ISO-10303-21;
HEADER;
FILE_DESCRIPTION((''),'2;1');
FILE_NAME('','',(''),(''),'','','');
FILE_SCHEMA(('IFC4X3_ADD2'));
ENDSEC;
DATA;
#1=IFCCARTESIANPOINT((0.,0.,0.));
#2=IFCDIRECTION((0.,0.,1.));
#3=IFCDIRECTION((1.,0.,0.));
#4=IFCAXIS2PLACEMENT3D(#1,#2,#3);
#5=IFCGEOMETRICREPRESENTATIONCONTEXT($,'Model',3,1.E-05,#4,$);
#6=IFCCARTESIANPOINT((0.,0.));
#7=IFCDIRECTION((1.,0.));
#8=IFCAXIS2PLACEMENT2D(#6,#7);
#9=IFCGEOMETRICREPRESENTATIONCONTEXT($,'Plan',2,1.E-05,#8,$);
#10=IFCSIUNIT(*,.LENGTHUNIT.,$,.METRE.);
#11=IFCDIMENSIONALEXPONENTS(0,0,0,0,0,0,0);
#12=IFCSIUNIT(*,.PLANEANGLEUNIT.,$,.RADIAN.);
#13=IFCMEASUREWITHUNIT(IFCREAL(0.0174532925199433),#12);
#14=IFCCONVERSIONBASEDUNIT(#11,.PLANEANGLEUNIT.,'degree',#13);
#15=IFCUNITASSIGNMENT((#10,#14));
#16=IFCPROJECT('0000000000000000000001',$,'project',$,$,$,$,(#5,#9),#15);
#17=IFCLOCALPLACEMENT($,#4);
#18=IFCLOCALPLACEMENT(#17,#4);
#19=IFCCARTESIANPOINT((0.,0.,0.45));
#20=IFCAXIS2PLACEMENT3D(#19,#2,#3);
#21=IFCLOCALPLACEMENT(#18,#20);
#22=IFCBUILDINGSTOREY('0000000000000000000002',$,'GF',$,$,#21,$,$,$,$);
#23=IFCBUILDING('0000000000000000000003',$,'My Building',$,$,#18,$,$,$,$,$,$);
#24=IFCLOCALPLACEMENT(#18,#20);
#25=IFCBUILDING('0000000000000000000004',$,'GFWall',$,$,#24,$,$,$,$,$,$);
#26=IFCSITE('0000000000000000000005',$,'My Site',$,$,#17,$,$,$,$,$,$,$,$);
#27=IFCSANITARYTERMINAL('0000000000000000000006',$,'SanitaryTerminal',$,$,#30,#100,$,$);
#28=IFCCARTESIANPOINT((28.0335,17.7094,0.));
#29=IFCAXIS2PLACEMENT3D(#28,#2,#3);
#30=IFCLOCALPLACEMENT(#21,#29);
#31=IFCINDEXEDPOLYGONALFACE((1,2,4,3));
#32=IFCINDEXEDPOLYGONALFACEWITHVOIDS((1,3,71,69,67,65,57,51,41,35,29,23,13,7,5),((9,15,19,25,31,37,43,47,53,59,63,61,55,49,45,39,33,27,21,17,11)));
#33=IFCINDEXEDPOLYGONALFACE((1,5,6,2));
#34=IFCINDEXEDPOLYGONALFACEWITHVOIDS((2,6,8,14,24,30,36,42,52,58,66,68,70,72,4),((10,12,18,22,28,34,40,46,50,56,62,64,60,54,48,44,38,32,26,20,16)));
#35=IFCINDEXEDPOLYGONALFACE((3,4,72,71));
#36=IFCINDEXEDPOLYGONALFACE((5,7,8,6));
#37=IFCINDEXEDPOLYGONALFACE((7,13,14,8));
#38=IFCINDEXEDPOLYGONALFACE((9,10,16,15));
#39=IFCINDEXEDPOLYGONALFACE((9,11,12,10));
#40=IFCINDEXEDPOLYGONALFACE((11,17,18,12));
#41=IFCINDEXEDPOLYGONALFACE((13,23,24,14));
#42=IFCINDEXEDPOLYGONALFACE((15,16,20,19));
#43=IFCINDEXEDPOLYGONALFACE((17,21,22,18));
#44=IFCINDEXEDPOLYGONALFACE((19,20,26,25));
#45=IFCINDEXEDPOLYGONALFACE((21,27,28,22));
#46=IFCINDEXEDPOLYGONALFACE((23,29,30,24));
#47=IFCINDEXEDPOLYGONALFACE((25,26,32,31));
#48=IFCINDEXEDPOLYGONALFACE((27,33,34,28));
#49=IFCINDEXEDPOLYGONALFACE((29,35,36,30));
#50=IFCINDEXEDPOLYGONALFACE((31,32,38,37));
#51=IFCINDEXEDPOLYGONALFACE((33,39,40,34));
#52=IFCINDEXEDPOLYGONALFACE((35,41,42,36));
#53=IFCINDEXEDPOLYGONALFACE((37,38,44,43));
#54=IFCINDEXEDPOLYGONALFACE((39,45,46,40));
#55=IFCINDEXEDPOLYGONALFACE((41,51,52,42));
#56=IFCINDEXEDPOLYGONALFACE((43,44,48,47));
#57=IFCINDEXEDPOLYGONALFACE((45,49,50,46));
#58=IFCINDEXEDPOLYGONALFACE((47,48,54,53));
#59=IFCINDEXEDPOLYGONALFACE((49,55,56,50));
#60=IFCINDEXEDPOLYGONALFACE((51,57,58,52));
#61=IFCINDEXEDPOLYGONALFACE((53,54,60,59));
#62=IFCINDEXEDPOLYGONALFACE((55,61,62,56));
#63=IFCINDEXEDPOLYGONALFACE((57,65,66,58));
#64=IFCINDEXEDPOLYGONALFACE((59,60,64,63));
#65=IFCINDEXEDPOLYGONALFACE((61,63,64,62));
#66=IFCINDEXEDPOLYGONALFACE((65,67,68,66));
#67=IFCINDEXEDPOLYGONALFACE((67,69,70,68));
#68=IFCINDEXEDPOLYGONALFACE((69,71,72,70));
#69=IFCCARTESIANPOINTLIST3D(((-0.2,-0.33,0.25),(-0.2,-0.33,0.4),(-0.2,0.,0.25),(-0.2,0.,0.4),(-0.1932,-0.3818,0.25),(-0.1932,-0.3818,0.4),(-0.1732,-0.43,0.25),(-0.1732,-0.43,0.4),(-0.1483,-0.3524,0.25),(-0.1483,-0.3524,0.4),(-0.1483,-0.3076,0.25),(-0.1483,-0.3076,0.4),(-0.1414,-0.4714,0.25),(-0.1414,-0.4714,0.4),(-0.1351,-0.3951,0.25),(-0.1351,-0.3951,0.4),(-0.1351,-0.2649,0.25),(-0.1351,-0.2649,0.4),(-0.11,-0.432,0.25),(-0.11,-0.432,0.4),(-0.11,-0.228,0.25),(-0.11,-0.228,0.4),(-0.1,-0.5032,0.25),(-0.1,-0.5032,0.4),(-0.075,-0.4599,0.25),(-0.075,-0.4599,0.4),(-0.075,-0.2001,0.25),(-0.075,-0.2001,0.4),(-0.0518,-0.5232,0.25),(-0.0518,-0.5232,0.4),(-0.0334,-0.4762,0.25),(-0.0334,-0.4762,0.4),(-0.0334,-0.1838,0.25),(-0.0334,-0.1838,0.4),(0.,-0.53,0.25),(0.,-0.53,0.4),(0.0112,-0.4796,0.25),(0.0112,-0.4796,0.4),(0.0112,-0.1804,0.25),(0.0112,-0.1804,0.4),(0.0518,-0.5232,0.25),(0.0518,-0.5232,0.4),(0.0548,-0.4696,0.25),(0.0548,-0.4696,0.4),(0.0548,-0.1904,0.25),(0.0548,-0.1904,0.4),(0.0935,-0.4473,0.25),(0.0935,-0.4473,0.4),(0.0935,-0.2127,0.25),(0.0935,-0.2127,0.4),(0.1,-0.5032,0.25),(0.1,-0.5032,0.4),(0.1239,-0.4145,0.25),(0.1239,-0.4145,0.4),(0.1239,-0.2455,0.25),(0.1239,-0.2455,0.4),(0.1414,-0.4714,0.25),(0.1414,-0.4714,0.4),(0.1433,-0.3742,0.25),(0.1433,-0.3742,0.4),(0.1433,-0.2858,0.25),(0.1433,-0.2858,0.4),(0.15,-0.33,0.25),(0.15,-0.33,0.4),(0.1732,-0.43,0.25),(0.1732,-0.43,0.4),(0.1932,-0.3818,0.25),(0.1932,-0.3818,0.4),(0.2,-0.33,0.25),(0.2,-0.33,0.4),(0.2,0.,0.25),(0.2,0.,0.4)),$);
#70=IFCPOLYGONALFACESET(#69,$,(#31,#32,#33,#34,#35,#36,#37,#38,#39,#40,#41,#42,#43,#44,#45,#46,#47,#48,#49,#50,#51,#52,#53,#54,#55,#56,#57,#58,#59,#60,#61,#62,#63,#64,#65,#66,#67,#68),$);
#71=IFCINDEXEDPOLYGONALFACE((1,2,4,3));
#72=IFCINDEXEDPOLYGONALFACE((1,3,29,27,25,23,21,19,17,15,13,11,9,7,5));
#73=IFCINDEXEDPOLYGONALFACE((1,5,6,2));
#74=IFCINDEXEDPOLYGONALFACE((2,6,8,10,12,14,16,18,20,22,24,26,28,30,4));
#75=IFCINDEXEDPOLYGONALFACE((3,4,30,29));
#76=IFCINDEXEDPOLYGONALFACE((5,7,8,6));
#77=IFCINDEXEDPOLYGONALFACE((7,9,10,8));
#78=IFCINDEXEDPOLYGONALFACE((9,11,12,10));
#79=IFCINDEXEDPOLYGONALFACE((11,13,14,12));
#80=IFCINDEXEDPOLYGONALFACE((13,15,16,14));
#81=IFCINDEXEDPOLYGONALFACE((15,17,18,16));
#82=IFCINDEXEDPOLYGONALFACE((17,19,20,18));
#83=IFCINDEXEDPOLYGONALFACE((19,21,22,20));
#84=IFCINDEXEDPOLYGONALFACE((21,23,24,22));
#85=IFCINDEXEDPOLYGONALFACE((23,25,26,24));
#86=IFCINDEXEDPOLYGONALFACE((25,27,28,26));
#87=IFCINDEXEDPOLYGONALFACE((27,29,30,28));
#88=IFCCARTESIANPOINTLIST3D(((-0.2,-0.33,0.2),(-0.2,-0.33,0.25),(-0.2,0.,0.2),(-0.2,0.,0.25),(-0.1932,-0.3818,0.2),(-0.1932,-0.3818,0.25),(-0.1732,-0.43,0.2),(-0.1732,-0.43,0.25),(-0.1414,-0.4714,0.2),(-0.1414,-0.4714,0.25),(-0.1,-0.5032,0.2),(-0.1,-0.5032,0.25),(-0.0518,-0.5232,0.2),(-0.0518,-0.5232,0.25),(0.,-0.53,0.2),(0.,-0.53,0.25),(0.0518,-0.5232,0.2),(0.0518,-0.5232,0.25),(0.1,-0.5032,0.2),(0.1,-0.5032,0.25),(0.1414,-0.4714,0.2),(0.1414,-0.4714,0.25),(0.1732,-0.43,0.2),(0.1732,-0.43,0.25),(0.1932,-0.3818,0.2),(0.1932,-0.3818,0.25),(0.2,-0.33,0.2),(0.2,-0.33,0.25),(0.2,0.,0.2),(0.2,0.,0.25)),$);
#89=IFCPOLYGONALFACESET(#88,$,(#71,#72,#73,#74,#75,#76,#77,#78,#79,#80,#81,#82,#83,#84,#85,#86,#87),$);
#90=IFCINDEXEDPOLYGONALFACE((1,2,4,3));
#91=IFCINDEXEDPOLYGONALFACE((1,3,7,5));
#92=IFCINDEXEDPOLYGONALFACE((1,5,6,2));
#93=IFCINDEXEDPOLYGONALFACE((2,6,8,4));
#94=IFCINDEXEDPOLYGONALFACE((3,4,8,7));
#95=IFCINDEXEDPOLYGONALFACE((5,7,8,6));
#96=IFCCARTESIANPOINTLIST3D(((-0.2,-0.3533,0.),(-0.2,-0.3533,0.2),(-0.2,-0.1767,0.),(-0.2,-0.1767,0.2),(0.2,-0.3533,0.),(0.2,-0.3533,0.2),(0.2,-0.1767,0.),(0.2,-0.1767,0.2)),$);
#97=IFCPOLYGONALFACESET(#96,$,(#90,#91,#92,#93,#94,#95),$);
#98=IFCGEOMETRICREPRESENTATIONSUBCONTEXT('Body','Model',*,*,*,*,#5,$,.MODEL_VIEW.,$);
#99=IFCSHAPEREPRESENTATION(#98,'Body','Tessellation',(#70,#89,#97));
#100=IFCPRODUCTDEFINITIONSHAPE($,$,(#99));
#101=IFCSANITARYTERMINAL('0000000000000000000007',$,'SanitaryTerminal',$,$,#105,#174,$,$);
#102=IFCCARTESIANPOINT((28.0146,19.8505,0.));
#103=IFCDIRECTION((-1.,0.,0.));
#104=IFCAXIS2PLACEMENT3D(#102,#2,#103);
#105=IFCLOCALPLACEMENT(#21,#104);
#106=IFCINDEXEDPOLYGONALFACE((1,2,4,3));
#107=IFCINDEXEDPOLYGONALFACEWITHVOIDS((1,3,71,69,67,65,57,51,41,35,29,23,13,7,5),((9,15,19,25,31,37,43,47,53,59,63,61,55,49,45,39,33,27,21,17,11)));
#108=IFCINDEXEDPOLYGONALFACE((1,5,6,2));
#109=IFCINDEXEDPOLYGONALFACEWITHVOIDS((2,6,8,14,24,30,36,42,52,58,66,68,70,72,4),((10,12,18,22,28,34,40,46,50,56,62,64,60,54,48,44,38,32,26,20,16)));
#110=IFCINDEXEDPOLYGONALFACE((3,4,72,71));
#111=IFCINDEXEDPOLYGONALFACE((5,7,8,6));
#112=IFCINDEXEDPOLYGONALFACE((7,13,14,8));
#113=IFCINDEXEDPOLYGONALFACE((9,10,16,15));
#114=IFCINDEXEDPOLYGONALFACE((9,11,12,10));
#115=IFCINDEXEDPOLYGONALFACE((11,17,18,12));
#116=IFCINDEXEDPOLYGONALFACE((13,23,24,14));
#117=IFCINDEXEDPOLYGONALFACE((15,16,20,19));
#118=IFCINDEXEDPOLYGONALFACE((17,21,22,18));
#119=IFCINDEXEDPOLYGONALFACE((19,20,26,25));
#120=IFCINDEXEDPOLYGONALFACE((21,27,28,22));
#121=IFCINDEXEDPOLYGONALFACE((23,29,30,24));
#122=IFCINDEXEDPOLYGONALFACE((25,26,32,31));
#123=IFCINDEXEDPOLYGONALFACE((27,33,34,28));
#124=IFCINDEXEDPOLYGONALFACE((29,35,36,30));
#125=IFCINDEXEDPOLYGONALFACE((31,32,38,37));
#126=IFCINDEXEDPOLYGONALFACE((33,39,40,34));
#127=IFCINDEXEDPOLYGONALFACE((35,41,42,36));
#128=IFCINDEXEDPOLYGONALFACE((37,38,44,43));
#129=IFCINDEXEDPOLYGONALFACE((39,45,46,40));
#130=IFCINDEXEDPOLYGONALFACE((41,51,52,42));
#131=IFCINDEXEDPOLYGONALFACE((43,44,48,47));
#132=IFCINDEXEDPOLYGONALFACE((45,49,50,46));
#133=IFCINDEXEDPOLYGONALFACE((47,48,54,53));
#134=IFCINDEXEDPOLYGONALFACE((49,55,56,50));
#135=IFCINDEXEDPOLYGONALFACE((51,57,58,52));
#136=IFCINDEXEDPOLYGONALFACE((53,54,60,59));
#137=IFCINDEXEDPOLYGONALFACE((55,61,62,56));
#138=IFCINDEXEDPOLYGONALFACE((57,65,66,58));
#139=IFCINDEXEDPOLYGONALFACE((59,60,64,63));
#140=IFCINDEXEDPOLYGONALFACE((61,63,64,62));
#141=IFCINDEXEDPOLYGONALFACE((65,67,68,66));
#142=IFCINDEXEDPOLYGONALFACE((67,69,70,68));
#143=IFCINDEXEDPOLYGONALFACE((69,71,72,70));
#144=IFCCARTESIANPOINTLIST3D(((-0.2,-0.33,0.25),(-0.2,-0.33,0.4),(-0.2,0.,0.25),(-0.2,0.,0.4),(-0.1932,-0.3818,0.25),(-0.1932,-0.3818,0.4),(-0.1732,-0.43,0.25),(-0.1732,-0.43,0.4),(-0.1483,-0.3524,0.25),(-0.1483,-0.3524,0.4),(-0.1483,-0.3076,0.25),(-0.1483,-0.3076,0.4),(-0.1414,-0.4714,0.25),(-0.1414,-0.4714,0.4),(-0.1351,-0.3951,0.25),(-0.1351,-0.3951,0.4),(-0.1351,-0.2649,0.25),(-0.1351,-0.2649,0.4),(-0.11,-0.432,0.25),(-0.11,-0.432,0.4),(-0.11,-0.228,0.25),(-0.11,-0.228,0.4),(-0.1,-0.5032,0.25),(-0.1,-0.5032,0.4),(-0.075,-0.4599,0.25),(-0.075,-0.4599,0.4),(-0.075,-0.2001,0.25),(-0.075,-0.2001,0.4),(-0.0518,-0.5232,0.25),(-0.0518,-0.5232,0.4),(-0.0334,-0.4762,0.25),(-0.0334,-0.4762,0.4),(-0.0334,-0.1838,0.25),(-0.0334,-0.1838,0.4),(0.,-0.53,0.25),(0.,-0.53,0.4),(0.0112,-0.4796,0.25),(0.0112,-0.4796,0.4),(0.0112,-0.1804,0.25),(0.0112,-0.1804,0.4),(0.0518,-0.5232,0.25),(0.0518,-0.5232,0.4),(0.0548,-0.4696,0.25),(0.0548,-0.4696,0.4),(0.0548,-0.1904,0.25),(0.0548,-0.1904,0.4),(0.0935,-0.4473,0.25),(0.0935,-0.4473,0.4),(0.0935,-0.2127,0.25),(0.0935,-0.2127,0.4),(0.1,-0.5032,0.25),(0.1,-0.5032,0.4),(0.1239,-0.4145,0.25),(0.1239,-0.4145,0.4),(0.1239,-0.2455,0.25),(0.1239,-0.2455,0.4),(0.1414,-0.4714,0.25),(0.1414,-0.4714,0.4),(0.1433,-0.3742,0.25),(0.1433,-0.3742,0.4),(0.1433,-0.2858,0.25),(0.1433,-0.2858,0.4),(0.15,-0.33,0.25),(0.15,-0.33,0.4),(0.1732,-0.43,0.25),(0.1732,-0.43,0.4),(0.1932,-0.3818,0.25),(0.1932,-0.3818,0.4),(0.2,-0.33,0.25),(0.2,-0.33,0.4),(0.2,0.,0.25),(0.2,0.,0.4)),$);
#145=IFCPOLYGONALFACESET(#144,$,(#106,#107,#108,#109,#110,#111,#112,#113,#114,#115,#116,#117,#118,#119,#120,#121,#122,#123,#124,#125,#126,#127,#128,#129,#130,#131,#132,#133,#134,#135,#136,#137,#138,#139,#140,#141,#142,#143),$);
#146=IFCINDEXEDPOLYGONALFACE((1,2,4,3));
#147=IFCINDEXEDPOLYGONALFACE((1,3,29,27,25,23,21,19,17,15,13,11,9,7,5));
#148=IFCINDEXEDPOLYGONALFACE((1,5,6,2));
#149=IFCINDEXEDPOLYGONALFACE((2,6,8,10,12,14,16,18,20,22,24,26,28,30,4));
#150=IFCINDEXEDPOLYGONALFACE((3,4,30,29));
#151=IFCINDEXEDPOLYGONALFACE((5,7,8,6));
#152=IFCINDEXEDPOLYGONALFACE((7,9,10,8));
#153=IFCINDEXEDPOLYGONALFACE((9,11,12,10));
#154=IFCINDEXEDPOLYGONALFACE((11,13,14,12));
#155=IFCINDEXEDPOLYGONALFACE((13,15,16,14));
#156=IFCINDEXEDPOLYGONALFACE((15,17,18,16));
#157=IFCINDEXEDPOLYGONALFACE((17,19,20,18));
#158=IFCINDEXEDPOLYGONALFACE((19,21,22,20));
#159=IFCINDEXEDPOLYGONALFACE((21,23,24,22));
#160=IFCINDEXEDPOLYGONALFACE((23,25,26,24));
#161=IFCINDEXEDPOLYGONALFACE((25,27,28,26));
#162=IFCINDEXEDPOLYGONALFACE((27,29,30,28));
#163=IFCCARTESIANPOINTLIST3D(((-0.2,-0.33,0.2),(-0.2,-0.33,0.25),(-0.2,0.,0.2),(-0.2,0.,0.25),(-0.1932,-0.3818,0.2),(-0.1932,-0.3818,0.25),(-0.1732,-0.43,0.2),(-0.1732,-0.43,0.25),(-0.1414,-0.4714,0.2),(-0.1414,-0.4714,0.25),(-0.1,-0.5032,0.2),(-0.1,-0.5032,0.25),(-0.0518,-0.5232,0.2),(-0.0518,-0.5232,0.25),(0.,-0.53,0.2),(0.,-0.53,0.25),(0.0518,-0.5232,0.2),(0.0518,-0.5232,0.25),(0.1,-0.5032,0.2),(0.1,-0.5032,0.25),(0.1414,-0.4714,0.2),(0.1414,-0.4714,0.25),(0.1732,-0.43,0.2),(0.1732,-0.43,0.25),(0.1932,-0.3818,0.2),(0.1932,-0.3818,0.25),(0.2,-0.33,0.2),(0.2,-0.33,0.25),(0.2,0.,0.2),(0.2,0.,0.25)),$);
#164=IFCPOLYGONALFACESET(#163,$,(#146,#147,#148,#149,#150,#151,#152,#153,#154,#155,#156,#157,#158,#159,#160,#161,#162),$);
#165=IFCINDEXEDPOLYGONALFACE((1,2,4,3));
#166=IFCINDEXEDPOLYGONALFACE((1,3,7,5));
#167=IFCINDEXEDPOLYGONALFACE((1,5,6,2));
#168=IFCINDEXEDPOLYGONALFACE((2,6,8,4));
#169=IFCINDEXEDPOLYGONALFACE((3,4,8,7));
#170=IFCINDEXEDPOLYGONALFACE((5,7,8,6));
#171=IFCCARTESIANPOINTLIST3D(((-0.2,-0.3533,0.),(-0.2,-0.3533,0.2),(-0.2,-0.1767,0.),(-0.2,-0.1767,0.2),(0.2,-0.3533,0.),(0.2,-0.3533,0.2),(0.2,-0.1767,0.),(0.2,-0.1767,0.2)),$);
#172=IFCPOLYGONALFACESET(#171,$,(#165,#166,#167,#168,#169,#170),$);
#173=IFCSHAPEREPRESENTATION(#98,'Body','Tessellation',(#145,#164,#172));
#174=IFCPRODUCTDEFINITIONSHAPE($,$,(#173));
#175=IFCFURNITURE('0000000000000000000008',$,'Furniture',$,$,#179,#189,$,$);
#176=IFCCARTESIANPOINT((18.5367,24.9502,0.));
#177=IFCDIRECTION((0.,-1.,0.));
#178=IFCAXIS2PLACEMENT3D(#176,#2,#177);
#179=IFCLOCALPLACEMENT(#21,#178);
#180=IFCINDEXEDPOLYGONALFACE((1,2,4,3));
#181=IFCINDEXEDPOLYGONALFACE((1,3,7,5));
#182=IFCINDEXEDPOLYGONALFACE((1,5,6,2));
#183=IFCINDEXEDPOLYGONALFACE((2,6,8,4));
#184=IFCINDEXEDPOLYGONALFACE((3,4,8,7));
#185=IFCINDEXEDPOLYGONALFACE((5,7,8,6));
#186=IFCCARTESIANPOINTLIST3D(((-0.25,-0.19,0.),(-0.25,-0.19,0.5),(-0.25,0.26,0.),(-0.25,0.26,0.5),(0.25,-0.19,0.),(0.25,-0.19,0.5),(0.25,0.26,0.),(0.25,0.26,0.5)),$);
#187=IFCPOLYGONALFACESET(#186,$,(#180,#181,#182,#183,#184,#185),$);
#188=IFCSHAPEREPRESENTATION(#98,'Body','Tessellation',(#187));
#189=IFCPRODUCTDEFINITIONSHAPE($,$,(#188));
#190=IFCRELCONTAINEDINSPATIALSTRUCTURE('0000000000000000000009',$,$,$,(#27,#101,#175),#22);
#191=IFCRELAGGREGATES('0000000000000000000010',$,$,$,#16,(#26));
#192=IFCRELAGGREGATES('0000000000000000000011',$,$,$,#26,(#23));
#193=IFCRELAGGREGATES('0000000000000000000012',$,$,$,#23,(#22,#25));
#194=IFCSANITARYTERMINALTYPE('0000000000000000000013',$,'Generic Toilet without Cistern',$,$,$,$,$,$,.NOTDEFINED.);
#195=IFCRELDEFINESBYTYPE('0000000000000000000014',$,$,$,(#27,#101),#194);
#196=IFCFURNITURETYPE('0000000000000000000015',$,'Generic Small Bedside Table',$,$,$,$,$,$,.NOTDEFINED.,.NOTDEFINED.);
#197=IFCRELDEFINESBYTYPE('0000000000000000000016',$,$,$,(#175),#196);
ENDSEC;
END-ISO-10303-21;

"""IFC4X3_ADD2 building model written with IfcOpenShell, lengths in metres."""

from ifc_helpers import new_model, entity, si_unit, converted_unit, frame, frame_2d, origin_with_axes, origin_2d_with_axis, place, context, subcontext, project, spatial, line, arc, indexed_curve, circle_curve, outline, extrude, shape, source, transform, mapped, type_object, type_shapes, element, save


model = new_model("IFC4X3_ADD2")

# Units and contexts
model_context = context("Model", 3, precision=1e-05, world=origin_with_axes())
plan_context = context("Plan", 2, precision=1e-05, world=origin_2d_with_axis())
body_context_1 = subcontext(model_context, "Body", "Model", "MODEL_VIEW")
body_context_2 = subcontext(plan_context, "Body", "Plan", "PLAN_VIEW")
ifc_project = project(units=[si_unit("LENGTHUNIT", "METRE"), converted_unit("PLANEANGLEUNIT", "degree", entity("IfcReal", 0.0174532925199433), si_unit("PLANEANGLEUNIT", "RADIAN"), dimensions=[0, 0, 0, 0, 0, 0, 0])], contexts=[model_context, plan_context])

# Site, building, storey
site_placement = place(None, origin_with_axes())
site = spatial("IfcSite", under=ifc_project, at=site_placement, Name="My Site")
building_1_placement = place(site_placement, origin_with_axes())
building_1 = spatial("IfcBuilding", under=site, at=building_1_placement, Name="My Building")
storey_placement = place(building_1_placement, frame((0.0, 0.0, 0.45), z_axis=(0.0, 0.0, 1.0), x_axis=(1.0, 0.0, 0.0)))
storey = spatial("IfcBuildingStorey", under=building_1, at=storey_placement, Name="GF")

# Shared definitions
building_2_placement = place(building_1_placement, frame((0.0, 0.0, 0.45), z_axis=(0.0, 0.0, 1.0), x_axis=(1.0, 0.0, 0.0)))
building_2 = spatial("IfcBuilding", under=building_1, at=building_2_placement, Name="GFWall")

# Sanitary terminals
sanitary_terminal_type_1 = type_object("IfcSanitaryTerminalType", Name="Generic Toilet without Cistern", PredefinedType="NOTDEFINED")
shared_shape_1 = source(origin_with_axes(), body_context_1, "Body", "SweptSolid", [
    extrude(outline(indexed_curve([(-0.2, 0.0), (0.2, 0.0), (0.2, -0.33), (0.1414, -0.4714), (0.0, -0.53), (-0.1414, -0.4714), (-0.2, -0.33)], segments=[line(1, 2), line(2, 3), arc(3, 4, 5), arc(5, 6, 7), line(7, 1)]), holes=[circle_curve(frame_2d((0.0, -0.33)), 0.15)]), frame((0.0, 0.0, 0.25), z_axis=(0.0, 0.0, 1.0), x_axis=(1.0, 0.0, 0.0)), (0.0, 0.0, 1.0), 0.15),
    extrude(outline(indexed_curve([(-0.2, 0.0), (0.2, 0.0), (0.2, -0.33), (0.1414, -0.4714), (0.0, -0.53), (-0.1414, -0.4714), (-0.2, -0.33)], segments=[line(1, 2), line(2, 3), arc(3, 4, 5), arc(5, 6, 7), line(7, 1)])), frame((0.0, 0.0, 0.2), z_axis=(0.0, 0.0, 1.0), x_axis=(1.0, 0.0, 0.0)), (0.0, 0.0, 1.0), 0.05),
    extrude(outline(indexed_curve([(-0.2, -0.1767), (0.2, -0.1767), (0.2, -0.3533), (-0.2, -0.3533)], segments=[line(1, 2, 3, 4, 1)])), origin_with_axes(), (0.0, 0.0, 1.0), 0.2),
])
shared_shape_2 = source(origin_with_axes(), body_context_2, "Body", "Annotation2D", [
    entity("IfcGeometricCurveSet", [entity("IfcIndexedPolyCurve", entity("IfcCartesianPointList2D", [[-0.1068, -0.124], [-0.0957, -0.1129], [-0.0804, -0.1088], [0.0804, -0.1088], [0.0957, -0.1129], [0.1068, -0.124], [0.1109, -0.1393], [0.1109, -0.3476], [0.1025, -0.3926], [0.0784, -0.4308], [0.0424, -0.4563], [0.0, -0.4652], [-0.0424, -0.4563], [-0.0784, -0.4308], [-0.1025, -0.3926], [-0.1109, -0.3476], [-0.1109, -0.1393]]), [entity("IfcLineIndex", [1, 2, 3, 4, 5, 6, 7, 8, 9, 10, 11, 12, 13, 14, 15, 16, 17, 1])]), entity("IfcIndexedPolyCurve", entity("IfcCartesianPointList2D", [[-0.1962, -0.2314], [-0.1848, -0.301], [-0.1764, -0.3339], [-0.1663, -0.3651], [-0.1546, -0.3944], [-0.1414, -0.4213], [-0.1269, -0.4458], [-0.1111, -0.4675], [-0.0943, -0.4862], [-0.0765, -0.5018], [-0.0581, -0.514], [-0.039, -0.5229], [-0.0196, -0.5282], [0.0, -0.53], [0.0196, -0.5282], [0.039, -0.5229], [0.0581, -0.514], [0.0765, -0.5018], [0.0943, -0.4862], [0.1111, -0.4675], [0.1269, -0.4458], [0.1414, -0.4213], [0.1546, -0.3944], [0.1663, -0.3651], [0.1764, -0.3339], [0.1848, -0.301], [0.1962, -0.2314], [0.2, -0.159], [0.1872, 0.0], [-0.1872, 0.0], [-0.2, -0.159]]), [entity("IfcLineIndex", [1, 2, 3, 4, 5, 6, 7, 8, 9, 10, 11, 12, 13, 14, 15, 16, 17, 18, 19, 20, 21, 22, 23, 24, 25, 26, 27, 28, 29, 30, 31, 1])])]),
])
type_shapes(sanitary_terminal_type_1, [shared_shape_1, shared_shape_2])
for number, where, z_axis, x_axis, name in (
    (1, (28.0335, 17.7094, 0.0), (0.0, 0.0, 1.0), (1.0, 0.0, 0.0), "SanitaryTerminal"),
    (2, (28.0146, 19.8505, 0.0), (0.0, 0.0, 1.0), (-1.0, 0.0, 0.0), "SanitaryTerminal"),
):
    element("IfcSanitaryTerminal", number, at=place(storey_placement, frame(where, z_axis=z_axis, x_axis=x_axis)), inside=storey, type_object=sanitary_terminal_type_1, Name=name, shapes=[
        shape(body_context_1, "Body", "MappedRepresentation", [mapped(shared_shape_1, transform((0.0, 0.0, 0.0), x_axis=(1.0, 0.0, 0.0), y_axis=(0.0, 1.0, 0.0), z_axis=(0.0, 0.0, 1.0), scale=1.0))]),
        shape(body_context_2, "Body", "MappedRepresentation", [mapped(shared_shape_2, transform((0.0, 0.0, 0.0), x_axis=(1.0, 0.0, 0.0), y_axis=(0.0, 1.0, 0.0), z_axis=(0.0, 0.0, 1.0), scale=1.0))]),
    ])

# Furniture
furniture_type_1 = type_object("IfcFurnitureType", Name="Generic Small Bedside Table", AssemblyPlace="NOTDEFINED", PredefinedType="NOTDEFINED")
shared_shape_3 = source(origin_with_axes(), body_context_1, "Body", "SweptSolid", [
    extrude(outline(indexed_curve([(0.0, 0.0), (0.5, 0.0), (0.5, 0.45), (0.0, 0.45), (0.0, 0.0)])), frame((-0.25, -0.19, 0.0), z_axis=(0.0, 0.0, 1.0), x_axis=(1.0, 0.0, 0.0)), (0.0, 0.0, 1.0), 0.5),
])
shared_shape_4 = source(origin_with_axes(), body_context_2, "Body", "Annotation2D", [
    entity("IfcGeometricCurveSet", [entity("IfcIndexedPolyCurve", entity("IfcCartesianPointList2D", [[-0.25, -0.19], [0.25, -0.19], [0.25, 0.26], [-0.25, 0.26]]), [entity("IfcLineIndex", [1, 2]), entity("IfcLineIndex", [2, 3]), entity("IfcLineIndex", [3, 4]), entity("IfcLineIndex", [4, 1])])]),
])
type_shapes(furniture_type_1, [shared_shape_3, shared_shape_4])
for number, where, z_axis, x_axis, name in (
    (3, (18.5367, 24.9502, 0.0), (0.0, 0.0, 1.0), (0.0, -1.0, 0.0), "Furniture"),
):
    element("IfcFurniture", number, at=place(storey_placement, frame(where, z_axis=z_axis, x_axis=x_axis)), inside=storey, type_object=furniture_type_1, Name=name, shapes=[
        shape(body_context_1, "Body", "MappedRepresentation", [mapped(shared_shape_3, transform((0.0, 0.0, 0.0), x_axis=(1.0, 0.0, 0.0), y_axis=(0.0, 1.0, 0.0), z_axis=(0.0, 0.0, 1.0), scale=1.0))]),
        shape(body_context_2, "Body", "MappedRepresentation", [mapped(shared_shape_4, transform((0.0, 0.0, 0.0), x_axis=(1.0, 0.0, 0.0), y_axis=(0.0, 1.0, 0.0), z_axis=(0.0, 0.0, 1.0), scale=1.0))]),
    ])

save(model, "model.ifc")
